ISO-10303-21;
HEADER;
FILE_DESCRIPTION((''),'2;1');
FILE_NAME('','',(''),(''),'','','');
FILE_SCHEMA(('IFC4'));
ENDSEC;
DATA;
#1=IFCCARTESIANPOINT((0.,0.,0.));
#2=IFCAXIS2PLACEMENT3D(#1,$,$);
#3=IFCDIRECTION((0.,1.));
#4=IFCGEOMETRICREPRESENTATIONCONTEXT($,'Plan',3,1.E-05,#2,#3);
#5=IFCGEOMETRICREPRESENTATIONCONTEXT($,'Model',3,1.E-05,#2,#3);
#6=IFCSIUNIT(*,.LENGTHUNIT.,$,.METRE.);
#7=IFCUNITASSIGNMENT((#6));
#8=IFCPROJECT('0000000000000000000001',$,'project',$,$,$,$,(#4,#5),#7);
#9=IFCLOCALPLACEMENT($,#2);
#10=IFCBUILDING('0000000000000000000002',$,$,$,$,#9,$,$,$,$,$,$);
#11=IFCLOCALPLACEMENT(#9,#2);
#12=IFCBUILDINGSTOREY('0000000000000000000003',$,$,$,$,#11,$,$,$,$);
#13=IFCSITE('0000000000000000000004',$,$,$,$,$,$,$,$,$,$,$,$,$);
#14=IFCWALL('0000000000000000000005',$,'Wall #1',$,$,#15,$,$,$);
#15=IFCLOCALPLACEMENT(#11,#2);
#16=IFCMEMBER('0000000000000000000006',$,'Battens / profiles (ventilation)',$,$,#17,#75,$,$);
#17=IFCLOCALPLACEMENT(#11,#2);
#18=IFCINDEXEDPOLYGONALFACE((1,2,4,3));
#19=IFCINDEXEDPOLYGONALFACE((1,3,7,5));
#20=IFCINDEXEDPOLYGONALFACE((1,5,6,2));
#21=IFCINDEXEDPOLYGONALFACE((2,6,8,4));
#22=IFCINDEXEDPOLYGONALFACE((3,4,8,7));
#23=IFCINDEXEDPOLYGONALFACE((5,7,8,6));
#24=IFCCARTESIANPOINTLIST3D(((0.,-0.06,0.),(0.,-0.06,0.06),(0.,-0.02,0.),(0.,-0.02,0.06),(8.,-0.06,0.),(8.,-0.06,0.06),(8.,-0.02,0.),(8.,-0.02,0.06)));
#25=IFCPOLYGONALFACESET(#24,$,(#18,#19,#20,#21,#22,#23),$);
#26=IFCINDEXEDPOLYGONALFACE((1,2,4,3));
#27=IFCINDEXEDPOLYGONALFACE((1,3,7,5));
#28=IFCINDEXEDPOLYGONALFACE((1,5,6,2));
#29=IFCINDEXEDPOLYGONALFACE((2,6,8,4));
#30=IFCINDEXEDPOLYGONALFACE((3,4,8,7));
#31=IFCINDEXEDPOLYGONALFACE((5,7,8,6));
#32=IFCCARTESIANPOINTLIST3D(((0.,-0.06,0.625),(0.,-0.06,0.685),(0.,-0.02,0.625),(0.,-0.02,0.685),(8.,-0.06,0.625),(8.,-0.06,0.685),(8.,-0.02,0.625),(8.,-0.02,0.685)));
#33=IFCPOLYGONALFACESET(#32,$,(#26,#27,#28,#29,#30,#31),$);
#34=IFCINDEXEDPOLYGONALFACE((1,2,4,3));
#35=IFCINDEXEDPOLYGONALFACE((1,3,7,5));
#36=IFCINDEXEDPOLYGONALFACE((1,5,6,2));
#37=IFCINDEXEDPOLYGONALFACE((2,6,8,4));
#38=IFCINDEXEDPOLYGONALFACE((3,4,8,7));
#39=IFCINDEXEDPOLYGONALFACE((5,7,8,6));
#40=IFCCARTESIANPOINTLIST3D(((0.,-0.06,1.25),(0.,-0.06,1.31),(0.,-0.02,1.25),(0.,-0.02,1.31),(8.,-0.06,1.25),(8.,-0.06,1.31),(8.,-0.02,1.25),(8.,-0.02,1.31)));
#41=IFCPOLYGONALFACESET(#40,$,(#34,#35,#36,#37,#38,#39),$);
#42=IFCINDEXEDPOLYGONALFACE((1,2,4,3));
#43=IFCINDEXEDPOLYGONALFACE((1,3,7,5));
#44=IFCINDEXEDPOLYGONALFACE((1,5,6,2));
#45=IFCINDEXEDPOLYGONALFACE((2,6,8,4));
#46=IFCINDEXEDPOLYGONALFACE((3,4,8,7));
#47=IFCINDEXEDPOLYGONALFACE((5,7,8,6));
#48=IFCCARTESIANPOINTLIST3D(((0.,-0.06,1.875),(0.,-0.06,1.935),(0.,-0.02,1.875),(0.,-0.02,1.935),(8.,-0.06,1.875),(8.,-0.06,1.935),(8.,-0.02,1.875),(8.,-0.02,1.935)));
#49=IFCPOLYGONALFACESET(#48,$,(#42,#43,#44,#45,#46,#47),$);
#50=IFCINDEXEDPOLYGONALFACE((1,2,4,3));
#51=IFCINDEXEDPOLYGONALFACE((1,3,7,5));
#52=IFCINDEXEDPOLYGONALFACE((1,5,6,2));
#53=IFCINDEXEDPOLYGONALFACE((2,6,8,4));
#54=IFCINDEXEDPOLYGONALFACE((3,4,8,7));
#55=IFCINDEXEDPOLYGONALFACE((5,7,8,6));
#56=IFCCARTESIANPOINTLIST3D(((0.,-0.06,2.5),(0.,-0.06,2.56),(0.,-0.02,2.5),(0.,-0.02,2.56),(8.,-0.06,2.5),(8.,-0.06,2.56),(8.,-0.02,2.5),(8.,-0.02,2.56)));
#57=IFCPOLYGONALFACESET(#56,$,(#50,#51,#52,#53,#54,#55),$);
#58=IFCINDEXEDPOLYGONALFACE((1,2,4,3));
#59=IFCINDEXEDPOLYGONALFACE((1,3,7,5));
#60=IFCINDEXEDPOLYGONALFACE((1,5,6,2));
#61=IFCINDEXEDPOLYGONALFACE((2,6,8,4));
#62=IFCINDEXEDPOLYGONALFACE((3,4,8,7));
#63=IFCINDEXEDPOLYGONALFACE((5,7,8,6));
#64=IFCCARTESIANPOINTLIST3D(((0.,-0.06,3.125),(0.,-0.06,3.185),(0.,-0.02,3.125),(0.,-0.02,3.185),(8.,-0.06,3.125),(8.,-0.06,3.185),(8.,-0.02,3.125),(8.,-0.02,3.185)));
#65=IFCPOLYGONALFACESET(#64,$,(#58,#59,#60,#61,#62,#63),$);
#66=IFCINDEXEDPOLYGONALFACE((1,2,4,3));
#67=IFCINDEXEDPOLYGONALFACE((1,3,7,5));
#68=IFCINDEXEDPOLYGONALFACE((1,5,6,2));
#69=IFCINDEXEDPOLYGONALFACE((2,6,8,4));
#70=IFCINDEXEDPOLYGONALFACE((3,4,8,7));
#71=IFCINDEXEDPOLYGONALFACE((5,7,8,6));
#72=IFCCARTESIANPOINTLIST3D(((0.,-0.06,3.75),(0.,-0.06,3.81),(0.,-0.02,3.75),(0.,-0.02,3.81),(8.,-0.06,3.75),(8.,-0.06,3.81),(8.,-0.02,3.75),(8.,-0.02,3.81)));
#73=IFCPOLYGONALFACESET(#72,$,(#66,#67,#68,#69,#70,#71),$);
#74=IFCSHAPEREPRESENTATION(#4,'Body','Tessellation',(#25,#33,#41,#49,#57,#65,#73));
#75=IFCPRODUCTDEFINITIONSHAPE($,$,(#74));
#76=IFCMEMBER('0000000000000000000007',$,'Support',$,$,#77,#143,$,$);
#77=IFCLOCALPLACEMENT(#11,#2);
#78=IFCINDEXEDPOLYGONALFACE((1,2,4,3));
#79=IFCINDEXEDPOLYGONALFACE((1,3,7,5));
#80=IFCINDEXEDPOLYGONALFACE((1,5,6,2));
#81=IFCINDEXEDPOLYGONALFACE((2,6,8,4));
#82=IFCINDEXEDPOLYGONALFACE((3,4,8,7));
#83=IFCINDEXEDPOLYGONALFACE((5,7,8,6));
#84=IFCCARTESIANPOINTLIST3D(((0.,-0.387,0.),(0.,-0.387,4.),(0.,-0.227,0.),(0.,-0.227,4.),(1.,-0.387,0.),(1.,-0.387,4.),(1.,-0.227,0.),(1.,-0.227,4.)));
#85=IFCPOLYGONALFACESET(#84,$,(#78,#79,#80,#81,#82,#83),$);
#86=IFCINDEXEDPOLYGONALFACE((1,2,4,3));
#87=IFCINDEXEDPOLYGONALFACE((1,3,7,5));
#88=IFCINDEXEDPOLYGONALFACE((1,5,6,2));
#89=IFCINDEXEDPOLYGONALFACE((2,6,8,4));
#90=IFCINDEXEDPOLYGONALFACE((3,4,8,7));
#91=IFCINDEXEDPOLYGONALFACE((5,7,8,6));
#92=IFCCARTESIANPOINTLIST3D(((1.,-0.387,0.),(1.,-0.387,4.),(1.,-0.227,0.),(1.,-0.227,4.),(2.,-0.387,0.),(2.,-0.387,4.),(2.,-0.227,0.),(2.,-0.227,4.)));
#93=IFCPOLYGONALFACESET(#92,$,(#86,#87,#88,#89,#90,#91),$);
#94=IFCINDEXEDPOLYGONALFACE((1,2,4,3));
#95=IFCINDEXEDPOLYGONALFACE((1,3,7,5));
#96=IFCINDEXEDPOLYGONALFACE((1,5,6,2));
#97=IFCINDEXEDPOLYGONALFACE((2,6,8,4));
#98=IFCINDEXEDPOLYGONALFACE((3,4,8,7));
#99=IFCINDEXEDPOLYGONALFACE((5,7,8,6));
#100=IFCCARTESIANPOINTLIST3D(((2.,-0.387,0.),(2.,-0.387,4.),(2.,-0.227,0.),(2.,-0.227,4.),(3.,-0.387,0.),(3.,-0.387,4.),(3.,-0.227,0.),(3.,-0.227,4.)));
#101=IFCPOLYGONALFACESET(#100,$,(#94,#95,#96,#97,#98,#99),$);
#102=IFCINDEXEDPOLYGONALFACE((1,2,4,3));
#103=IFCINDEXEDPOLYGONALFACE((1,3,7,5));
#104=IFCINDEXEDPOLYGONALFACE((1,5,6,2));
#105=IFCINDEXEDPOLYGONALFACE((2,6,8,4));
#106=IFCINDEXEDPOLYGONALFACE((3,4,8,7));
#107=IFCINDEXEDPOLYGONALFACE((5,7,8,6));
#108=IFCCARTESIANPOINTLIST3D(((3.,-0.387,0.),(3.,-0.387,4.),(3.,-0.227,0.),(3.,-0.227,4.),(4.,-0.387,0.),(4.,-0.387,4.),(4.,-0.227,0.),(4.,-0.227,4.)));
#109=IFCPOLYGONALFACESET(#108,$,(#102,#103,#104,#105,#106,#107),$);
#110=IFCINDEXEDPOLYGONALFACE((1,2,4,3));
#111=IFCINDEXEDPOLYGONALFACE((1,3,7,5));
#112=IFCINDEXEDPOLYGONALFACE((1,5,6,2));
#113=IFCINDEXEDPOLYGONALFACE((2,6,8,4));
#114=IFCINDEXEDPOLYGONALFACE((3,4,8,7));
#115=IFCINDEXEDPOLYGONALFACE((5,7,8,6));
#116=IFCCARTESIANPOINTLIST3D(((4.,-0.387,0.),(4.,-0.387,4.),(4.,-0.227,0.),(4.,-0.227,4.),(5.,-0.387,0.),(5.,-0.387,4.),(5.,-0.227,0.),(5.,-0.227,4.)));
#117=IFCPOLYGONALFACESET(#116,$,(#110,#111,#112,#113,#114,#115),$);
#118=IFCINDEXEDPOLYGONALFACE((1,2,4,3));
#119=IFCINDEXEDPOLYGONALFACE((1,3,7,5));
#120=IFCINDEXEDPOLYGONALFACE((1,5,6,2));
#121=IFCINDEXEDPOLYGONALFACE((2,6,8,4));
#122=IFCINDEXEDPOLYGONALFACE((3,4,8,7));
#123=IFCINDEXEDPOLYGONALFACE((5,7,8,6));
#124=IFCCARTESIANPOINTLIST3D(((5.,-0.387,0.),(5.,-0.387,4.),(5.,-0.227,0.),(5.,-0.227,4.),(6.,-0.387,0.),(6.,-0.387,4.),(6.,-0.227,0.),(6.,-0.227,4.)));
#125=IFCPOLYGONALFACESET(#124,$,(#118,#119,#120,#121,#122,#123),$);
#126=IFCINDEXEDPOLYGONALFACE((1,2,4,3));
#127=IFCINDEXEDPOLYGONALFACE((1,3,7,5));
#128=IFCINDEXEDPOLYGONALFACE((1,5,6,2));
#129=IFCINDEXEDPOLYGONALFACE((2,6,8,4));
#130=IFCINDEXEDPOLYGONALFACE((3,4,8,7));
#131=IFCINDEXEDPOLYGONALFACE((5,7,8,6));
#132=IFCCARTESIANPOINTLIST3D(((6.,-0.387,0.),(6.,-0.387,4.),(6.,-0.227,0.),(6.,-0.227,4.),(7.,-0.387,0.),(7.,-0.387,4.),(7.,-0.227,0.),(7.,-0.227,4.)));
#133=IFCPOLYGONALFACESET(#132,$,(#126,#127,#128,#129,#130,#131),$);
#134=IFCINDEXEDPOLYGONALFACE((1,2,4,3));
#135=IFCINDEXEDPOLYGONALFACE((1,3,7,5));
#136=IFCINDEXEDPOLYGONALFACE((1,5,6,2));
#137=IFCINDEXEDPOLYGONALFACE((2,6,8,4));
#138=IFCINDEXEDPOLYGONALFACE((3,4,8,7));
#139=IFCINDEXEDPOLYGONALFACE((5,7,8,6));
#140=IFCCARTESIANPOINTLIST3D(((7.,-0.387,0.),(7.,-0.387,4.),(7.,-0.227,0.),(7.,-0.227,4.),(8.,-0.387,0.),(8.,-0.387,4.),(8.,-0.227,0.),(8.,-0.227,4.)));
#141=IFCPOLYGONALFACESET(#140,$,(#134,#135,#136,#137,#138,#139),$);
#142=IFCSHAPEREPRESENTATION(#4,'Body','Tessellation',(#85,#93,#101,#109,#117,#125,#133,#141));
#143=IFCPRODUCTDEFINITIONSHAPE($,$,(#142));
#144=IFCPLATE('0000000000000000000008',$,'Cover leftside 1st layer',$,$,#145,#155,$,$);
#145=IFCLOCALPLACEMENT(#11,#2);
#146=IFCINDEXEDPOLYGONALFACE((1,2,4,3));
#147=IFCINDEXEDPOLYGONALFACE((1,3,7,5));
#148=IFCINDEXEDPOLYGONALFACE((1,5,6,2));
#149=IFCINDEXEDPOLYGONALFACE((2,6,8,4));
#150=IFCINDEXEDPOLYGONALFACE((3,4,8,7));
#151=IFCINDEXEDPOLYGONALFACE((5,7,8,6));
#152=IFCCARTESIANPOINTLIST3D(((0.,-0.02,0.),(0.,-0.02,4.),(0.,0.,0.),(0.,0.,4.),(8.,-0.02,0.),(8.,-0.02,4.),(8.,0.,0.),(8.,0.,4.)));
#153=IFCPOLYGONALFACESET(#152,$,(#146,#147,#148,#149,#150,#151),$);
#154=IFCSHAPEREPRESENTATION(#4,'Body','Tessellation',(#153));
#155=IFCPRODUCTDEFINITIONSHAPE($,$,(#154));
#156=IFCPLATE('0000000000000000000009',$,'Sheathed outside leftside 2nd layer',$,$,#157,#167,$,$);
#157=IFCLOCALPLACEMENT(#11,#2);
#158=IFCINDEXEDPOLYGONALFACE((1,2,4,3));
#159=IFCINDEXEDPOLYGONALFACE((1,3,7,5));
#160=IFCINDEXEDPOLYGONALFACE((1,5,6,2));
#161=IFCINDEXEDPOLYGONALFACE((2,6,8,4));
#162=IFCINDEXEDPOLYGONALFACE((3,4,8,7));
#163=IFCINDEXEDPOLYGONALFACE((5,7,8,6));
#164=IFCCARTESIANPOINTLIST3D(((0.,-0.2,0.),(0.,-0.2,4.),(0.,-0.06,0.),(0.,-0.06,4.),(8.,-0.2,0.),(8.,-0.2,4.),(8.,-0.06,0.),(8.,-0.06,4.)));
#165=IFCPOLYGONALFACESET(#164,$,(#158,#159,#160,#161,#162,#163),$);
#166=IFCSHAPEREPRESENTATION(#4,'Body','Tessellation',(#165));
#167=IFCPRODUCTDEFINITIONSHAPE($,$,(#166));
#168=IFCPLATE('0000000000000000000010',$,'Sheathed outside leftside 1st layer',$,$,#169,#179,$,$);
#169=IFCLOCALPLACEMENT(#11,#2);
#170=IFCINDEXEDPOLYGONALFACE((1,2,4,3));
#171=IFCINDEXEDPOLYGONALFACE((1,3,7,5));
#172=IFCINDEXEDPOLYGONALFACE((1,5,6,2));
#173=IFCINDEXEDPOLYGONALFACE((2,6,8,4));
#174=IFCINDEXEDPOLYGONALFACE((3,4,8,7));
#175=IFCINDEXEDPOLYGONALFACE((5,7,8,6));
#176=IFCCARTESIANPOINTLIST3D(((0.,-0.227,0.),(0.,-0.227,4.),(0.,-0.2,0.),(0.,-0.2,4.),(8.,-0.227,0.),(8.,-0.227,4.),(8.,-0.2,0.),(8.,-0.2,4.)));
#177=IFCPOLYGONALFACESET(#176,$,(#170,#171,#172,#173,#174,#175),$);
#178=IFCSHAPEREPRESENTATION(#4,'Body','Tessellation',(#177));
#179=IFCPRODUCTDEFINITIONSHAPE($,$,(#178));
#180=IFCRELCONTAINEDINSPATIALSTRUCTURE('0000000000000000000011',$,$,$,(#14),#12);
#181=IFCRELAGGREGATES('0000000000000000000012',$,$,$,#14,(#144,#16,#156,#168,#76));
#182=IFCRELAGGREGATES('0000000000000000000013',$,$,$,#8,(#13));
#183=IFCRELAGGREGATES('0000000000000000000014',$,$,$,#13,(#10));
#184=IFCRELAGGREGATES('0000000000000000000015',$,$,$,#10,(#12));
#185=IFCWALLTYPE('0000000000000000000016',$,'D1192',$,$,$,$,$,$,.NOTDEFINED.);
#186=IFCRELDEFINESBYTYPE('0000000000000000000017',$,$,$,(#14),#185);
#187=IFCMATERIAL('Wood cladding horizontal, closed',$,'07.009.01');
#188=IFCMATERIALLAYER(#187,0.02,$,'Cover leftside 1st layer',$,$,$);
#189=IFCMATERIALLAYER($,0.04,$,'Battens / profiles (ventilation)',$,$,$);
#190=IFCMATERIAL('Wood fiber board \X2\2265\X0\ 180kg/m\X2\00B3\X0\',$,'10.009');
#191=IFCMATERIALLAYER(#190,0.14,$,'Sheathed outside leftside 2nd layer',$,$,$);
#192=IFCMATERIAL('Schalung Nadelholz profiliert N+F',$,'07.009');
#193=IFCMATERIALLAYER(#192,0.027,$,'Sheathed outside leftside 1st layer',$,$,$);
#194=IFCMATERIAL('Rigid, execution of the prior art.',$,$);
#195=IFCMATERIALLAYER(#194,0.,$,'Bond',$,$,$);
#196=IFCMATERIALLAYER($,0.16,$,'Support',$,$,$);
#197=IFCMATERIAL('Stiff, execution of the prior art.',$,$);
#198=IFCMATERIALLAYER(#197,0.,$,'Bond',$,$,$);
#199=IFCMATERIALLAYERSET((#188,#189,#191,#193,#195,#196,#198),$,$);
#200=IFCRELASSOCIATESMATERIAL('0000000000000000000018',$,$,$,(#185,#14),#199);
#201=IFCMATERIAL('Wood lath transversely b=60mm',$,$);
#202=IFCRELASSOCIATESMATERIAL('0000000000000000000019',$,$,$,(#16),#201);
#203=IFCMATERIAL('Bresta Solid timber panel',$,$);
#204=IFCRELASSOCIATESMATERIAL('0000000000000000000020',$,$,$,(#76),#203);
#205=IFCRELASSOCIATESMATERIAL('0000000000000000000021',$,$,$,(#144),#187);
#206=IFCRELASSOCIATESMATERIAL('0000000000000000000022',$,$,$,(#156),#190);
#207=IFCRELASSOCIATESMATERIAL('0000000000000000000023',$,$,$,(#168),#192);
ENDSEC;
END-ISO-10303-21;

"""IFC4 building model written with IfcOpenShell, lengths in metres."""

from ifc_helpers import new_model, si_unit, direction, frame, frame_2d, origin, origin_with_axes, place, context, project, spatial, rectangle, extrude, material, layer, layer_set, type_object, element, aggregate, save


model = new_model("IFC4")

# Units and contexts
plan_context = context("Plan", 3, precision=1e-05, world=origin(), true_north=direction((0.0, 1.0)))
model_context = context("Model", 3, precision=1e-05, world=origin(), true_north=direction((0.0, 1.0)))
ifc_project = project(units=[si_unit("LENGTHUNIT", "METRE")], contexts=[plan_context, model_context])

# Site, building, storey
site = spatial("IfcSite", under=ifc_project)
building_placement = place(None, origin())
building = spatial("IfcBuilding", under=site, at=building_placement)
storey_placement = place(building_placement, origin())
storey = spatial("IfcBuildingStorey", under=building, at=storey_placement)

# Wall, members, plates
ifc_material_1 = material(Name="Wood cladding horizontal, closed", Category="07.009.01")
ifc_layer_1 = layer(ifc_material_1, 0.02, Name="Cover leftside 1st layer")
ifc_layer_2 = layer(None, 0.04, Name="Battens / profiles (ventilation)")
ifc_material_2 = material(Name="Wood fiber board ≥ 180kg/m³", Category="10.009")
ifc_layer_3 = layer(ifc_material_2, 0.14, Name="Sheathed outside leftside 2nd layer")
ifc_material_3 = material(Name="Schalung Nadelholz profiliert N+F", Category="07.009")
ifc_layer_4 = layer(ifc_material_3, 0.027, Name="Sheathed outside leftside 1st layer")
ifc_material_4 = material(Name="Rigid, execution of the prior art.")
ifc_layer_5 = layer(ifc_material_4, 0.0, Name="Bond")
ifc_layer_6 = layer(None, 0.16, Name="Support")
ifc_material_5 = material(Name="Stiff, execution of the prior art.")
ifc_layer_7 = layer(ifc_material_5, 0.0, Name="Bond")
ifc_layer_set = layer_set([ifc_layer_1, ifc_layer_2, ifc_layer_3, ifc_layer_4, ifc_layer_5, ifc_layer_6, ifc_layer_7])
wall_type = type_object("IfcWallType", Name="D1192", PredefinedType="NOTDEFINED", material=ifc_layer_set)
wall_placement = place(None, frame((0.0, 0.0, 0.0), z_axis=(0.0, -1.0, 0.0), x_axis=(1.0, 0.0, 0.0)))
wall = element("IfcWall", 1, at=wall_placement, inside=storey, type_object=wall_type, material=ifc_layer_set, Name="Wall #1")
ifc_material_6 = material(Name="Wood lath transversely b=60mm")
member_1_placement = place(wall_placement, origin())
member_1 = element("IfcMember", 2, at=member_1_placement, material=ifc_material_6, Name="Battens / profiles (ventilation)", context=plan_context, shape_type="SweptSolid", body=[
    extrude(rectangle(XDim=0.06, YDim=0.04, at=frame_2d((0.03, 0.02), x_axis=(1.0, 0.0))), frame((0.0, 0.0, 0.02), z_axis=(1.0, 0.0, 0.0), x_axis=(0.0, 1.0, 0.0)), (0.0, 0.0, 1.0), 8.0),
    extrude(rectangle(XDim=0.06, YDim=0.04, at=frame_2d((0.03, 0.02), x_axis=(1.0, 0.0))), frame((0.0, 0.625, 0.02), z_axis=(1.0, 0.0, 0.0), x_axis=(0.0, 1.0, 0.0)), (0.0, 0.0, 1.0), 8.0),
    extrude(rectangle(XDim=0.06, YDim=0.04, at=frame_2d((0.03, 0.02), x_axis=(1.0, 0.0))), frame((0.0, 1.25, 0.02), z_axis=(1.0, 0.0, 0.0), x_axis=(0.0, 1.0, 0.0)), (0.0, 0.0, 1.0), 8.0),
    extrude(rectangle(XDim=0.06, YDim=0.04, at=frame_2d((0.03, 0.02), x_axis=(1.0, 0.0))), frame((0.0, 1.875, 0.02), z_axis=(1.0, 0.0, 0.0), x_axis=(0.0, 1.0, 0.0)), (0.0, 0.0, 1.0), 8.0),
    extrude(rectangle(XDim=0.06, YDim=0.04, at=frame_2d((0.03, 0.02), x_axis=(1.0, 0.0))), frame((0.0, 2.5, 0.02), z_axis=(1.0, 0.0, 0.0), x_axis=(0.0, 1.0, 0.0)), (0.0, 0.0, 1.0), 8.0),
    extrude(rectangle(XDim=0.06, YDim=0.04, at=frame_2d((0.03, 0.02), x_axis=(1.0, 0.0))), frame((0.0, 3.125, 0.02), z_axis=(1.0, 0.0, 0.0), x_axis=(0.0, 1.0, 0.0)), (0.0, 0.0, 1.0), 8.0),
    extrude(rectangle(XDim=0.06, YDim=0.04, at=frame_2d((0.03, 0.02), x_axis=(1.0, 0.0))), frame((0.0, 3.75, 0.02), z_axis=(1.0, 0.0, 0.0), x_axis=(0.0, 1.0, 0.0)), (0.0, 0.0, 1.0), 8.0),
])
ifc_material_7 = material(Name="Bresta Solid timber panel")
member_2_placement = place(wall_placement, origin())
member_2 = element("IfcMember", 3, at=member_2_placement, material=ifc_material_7, Name="Support", context=plan_context, shape_type="SweptSolid", body=[
    extrude(rectangle(XDim=1.0, YDim=0.16, at=frame_2d((0.5, 0.08), x_axis=(1.0, 0.0))), frame((0.0, 4.0, 0.227), z_axis=(0.0, -1.0, 0.0), x_axis=(1.0, 0.0, 0.0)), (0.0, 0.0, 1.0), 4.0),
    extrude(rectangle(XDim=1.0, YDim=0.16, at=frame_2d((0.5, 0.08), x_axis=(1.0, 0.0))), frame((1.0, 4.0, 0.227), z_axis=(0.0, -1.0, 0.0), x_axis=(1.0, 0.0, 0.0)), (0.0, 0.0, 1.0), 4.0),
    extrude(rectangle(XDim=1.0, YDim=0.16, at=frame_2d((0.5, 0.08), x_axis=(1.0, 0.0))), frame((2.0, 4.0, 0.227), z_axis=(0.0, -1.0, 0.0), x_axis=(1.0, 0.0, 0.0)), (0.0, 0.0, 1.0), 4.0),
    extrude(rectangle(XDim=1.0, YDim=0.16, at=frame_2d((0.5, 0.08), x_axis=(1.0, 0.0))), frame((3.0, 4.0, 0.227), z_axis=(0.0, -1.0, 0.0), x_axis=(1.0, 0.0, 0.0)), (0.0, 0.0, 1.0), 4.0),
    extrude(rectangle(XDim=1.0, YDim=0.16, at=frame_2d((0.5, 0.08), x_axis=(1.0, 0.0))), frame((4.0, 4.0, 0.227), z_axis=(0.0, -1.0, 0.0), x_axis=(1.0, 0.0, 0.0)), (0.0, 0.0, 1.0), 4.0),
    extrude(rectangle(XDim=1.0, YDim=0.16, at=frame_2d((0.5, 0.08), x_axis=(1.0, 0.0))), frame((5.0, 4.0, 0.227), z_axis=(0.0, -1.0, 0.0), x_axis=(1.0, 0.0, 0.0)), (0.0, 0.0, 1.0), 4.0),
    extrude(rectangle(XDim=1.0, YDim=0.16, at=frame_2d((0.5, 0.08), x_axis=(1.0, 0.0))), frame((6.0, 4.0, 0.227), z_axis=(0.0, -1.0, 0.0), x_axis=(1.0, 0.0, 0.0)), (0.0, 0.0, 1.0), 4.0),
    extrude(rectangle(XDim=1.0, YDim=0.16, at=frame_2d((0.5, 0.08), x_axis=(1.0, 0.0))), frame((7.0, 4.0, 0.227), z_axis=(0.0, -1.0, 0.0), x_axis=(1.0, 0.0, 0.0)), (0.0, 0.0, 1.0), 4.0),
])
plate_1_placement = place(wall_placement, origin())
plate_1 = element("IfcPlate", 4, at=plate_1_placement, material=ifc_material_1, Name="Cover leftside 1st layer", context=plan_context, shape_type="SweptSolid", body=[
    extrude(rectangle(XDim=8.0, YDim=4.0, at=frame_2d((4.0, 2.0), x_axis=(1.0, 0.0))), origin_with_axes(), (0.0, 0.0, 1.0), 0.02),
])
plate_2_placement = place(wall_placement, origin())
plate_2 = element("IfcPlate", 5, at=plate_2_placement, material=ifc_material_2, Name="Sheathed outside leftside 2nd layer", context=plan_context, shape_type="SweptSolid", body=[
    extrude(rectangle(XDim=8.0, YDim=4.0, at=frame_2d((4.0, 2.0), x_axis=(1.0, 0.0))), frame((0.0, 0.0, 0.06), z_axis=(0.0, 0.0, 1.0), x_axis=(1.0, 0.0, 0.0)), (0.0, 0.0, 1.0), 0.14),
])
plate_3_placement = place(wall_placement, origin())
plate_3 = element("IfcPlate", 6, at=plate_3_placement, material=ifc_material_3, Name="Sheathed outside leftside 1st layer", context=plan_context, shape_type="SweptSolid", body=[
    extrude(rectangle(XDim=8.0, YDim=4.0, at=frame_2d((4.0, 2.0), x_axis=(1.0, 0.0))), frame((0.0, 0.0, 0.2), z_axis=(0.0, 0.0, 1.0), x_axis=(1.0, 0.0, 0.0)), (0.0, 0.0, 1.0), 0.027),
])
aggregate(wall, [plate_1, member_1, plate_2, plate_3, member_2])

save(model, "model.ifc")
